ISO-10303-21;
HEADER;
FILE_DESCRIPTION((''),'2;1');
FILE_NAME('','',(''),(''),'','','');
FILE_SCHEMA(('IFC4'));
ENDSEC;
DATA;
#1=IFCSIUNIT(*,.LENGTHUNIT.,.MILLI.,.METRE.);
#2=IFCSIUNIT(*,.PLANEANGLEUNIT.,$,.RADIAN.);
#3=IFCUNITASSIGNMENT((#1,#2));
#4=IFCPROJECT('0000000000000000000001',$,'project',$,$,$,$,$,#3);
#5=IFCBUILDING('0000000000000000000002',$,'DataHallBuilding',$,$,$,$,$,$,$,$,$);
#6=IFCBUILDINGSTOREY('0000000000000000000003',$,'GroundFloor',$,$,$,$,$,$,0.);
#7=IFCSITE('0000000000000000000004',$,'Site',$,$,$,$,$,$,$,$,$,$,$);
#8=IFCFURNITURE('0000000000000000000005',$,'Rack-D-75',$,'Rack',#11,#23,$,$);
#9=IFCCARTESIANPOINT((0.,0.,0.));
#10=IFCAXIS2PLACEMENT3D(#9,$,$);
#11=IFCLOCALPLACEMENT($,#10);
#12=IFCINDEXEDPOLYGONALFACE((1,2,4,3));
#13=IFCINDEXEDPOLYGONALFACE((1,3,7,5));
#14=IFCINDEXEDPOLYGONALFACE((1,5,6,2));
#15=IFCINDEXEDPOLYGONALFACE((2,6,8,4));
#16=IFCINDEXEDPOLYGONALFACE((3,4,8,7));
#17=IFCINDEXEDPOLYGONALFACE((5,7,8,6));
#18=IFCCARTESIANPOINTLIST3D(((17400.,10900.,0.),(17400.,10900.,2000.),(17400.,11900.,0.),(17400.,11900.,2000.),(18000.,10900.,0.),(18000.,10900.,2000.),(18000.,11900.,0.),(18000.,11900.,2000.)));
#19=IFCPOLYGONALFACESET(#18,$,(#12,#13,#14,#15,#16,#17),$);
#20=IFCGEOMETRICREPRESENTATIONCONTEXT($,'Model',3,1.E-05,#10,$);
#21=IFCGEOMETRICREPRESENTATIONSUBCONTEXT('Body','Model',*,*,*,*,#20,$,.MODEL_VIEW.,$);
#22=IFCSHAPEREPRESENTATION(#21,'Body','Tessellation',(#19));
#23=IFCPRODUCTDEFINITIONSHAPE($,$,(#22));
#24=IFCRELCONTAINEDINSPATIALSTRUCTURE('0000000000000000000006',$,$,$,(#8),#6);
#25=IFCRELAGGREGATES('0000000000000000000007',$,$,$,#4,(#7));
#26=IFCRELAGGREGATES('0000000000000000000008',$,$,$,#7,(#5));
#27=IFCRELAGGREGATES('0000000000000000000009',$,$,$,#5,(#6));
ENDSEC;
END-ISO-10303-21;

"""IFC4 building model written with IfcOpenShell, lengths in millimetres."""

from ifc_helpers import new_model, si_unit, frame, origin, place, context, subcontext, project, spatial, rectangle, extrude, element, save


model = new_model("IFC4")

# Units and contexts
model_context = context("Model", 3, precision=1e-05, world=origin())
body_context = subcontext(model_context, "Body", "Model", "MODEL_VIEW")
ifc_project = project(units=[si_unit("LENGTHUNIT", "METRE", prefix="MILLI"), si_unit("PLANEANGLEUNIT", "RADIAN")])

# Site, building, storey
site = spatial("IfcSite", under=ifc_project, Name="Site")
building = spatial("IfcBuilding", under=site, Name="DataHallBuilding")
storey = spatial("IfcBuildingStorey", under=building, Name="GroundFloor", Elevation=0.0)

# Furniture
furniture_1_placement = place(None, origin())
element("IfcFurniture", 1, at=furniture_1_placement, inside=storey, Name="Rack-D-75", ObjectType="Rack", context=body_context, shape_type="SweptSolid", body=[
    extrude(rectangle(XDim=600.0, YDim=1000.0), frame((17700.0, 11400.0, 0.0), z_axis=(0.0, 0.0, 1.0), x_axis=(1.0, 0.0, 0.0)), (0.0, 0.0, 1.0), 2000.0),
])

save(model, "model.ifc")
